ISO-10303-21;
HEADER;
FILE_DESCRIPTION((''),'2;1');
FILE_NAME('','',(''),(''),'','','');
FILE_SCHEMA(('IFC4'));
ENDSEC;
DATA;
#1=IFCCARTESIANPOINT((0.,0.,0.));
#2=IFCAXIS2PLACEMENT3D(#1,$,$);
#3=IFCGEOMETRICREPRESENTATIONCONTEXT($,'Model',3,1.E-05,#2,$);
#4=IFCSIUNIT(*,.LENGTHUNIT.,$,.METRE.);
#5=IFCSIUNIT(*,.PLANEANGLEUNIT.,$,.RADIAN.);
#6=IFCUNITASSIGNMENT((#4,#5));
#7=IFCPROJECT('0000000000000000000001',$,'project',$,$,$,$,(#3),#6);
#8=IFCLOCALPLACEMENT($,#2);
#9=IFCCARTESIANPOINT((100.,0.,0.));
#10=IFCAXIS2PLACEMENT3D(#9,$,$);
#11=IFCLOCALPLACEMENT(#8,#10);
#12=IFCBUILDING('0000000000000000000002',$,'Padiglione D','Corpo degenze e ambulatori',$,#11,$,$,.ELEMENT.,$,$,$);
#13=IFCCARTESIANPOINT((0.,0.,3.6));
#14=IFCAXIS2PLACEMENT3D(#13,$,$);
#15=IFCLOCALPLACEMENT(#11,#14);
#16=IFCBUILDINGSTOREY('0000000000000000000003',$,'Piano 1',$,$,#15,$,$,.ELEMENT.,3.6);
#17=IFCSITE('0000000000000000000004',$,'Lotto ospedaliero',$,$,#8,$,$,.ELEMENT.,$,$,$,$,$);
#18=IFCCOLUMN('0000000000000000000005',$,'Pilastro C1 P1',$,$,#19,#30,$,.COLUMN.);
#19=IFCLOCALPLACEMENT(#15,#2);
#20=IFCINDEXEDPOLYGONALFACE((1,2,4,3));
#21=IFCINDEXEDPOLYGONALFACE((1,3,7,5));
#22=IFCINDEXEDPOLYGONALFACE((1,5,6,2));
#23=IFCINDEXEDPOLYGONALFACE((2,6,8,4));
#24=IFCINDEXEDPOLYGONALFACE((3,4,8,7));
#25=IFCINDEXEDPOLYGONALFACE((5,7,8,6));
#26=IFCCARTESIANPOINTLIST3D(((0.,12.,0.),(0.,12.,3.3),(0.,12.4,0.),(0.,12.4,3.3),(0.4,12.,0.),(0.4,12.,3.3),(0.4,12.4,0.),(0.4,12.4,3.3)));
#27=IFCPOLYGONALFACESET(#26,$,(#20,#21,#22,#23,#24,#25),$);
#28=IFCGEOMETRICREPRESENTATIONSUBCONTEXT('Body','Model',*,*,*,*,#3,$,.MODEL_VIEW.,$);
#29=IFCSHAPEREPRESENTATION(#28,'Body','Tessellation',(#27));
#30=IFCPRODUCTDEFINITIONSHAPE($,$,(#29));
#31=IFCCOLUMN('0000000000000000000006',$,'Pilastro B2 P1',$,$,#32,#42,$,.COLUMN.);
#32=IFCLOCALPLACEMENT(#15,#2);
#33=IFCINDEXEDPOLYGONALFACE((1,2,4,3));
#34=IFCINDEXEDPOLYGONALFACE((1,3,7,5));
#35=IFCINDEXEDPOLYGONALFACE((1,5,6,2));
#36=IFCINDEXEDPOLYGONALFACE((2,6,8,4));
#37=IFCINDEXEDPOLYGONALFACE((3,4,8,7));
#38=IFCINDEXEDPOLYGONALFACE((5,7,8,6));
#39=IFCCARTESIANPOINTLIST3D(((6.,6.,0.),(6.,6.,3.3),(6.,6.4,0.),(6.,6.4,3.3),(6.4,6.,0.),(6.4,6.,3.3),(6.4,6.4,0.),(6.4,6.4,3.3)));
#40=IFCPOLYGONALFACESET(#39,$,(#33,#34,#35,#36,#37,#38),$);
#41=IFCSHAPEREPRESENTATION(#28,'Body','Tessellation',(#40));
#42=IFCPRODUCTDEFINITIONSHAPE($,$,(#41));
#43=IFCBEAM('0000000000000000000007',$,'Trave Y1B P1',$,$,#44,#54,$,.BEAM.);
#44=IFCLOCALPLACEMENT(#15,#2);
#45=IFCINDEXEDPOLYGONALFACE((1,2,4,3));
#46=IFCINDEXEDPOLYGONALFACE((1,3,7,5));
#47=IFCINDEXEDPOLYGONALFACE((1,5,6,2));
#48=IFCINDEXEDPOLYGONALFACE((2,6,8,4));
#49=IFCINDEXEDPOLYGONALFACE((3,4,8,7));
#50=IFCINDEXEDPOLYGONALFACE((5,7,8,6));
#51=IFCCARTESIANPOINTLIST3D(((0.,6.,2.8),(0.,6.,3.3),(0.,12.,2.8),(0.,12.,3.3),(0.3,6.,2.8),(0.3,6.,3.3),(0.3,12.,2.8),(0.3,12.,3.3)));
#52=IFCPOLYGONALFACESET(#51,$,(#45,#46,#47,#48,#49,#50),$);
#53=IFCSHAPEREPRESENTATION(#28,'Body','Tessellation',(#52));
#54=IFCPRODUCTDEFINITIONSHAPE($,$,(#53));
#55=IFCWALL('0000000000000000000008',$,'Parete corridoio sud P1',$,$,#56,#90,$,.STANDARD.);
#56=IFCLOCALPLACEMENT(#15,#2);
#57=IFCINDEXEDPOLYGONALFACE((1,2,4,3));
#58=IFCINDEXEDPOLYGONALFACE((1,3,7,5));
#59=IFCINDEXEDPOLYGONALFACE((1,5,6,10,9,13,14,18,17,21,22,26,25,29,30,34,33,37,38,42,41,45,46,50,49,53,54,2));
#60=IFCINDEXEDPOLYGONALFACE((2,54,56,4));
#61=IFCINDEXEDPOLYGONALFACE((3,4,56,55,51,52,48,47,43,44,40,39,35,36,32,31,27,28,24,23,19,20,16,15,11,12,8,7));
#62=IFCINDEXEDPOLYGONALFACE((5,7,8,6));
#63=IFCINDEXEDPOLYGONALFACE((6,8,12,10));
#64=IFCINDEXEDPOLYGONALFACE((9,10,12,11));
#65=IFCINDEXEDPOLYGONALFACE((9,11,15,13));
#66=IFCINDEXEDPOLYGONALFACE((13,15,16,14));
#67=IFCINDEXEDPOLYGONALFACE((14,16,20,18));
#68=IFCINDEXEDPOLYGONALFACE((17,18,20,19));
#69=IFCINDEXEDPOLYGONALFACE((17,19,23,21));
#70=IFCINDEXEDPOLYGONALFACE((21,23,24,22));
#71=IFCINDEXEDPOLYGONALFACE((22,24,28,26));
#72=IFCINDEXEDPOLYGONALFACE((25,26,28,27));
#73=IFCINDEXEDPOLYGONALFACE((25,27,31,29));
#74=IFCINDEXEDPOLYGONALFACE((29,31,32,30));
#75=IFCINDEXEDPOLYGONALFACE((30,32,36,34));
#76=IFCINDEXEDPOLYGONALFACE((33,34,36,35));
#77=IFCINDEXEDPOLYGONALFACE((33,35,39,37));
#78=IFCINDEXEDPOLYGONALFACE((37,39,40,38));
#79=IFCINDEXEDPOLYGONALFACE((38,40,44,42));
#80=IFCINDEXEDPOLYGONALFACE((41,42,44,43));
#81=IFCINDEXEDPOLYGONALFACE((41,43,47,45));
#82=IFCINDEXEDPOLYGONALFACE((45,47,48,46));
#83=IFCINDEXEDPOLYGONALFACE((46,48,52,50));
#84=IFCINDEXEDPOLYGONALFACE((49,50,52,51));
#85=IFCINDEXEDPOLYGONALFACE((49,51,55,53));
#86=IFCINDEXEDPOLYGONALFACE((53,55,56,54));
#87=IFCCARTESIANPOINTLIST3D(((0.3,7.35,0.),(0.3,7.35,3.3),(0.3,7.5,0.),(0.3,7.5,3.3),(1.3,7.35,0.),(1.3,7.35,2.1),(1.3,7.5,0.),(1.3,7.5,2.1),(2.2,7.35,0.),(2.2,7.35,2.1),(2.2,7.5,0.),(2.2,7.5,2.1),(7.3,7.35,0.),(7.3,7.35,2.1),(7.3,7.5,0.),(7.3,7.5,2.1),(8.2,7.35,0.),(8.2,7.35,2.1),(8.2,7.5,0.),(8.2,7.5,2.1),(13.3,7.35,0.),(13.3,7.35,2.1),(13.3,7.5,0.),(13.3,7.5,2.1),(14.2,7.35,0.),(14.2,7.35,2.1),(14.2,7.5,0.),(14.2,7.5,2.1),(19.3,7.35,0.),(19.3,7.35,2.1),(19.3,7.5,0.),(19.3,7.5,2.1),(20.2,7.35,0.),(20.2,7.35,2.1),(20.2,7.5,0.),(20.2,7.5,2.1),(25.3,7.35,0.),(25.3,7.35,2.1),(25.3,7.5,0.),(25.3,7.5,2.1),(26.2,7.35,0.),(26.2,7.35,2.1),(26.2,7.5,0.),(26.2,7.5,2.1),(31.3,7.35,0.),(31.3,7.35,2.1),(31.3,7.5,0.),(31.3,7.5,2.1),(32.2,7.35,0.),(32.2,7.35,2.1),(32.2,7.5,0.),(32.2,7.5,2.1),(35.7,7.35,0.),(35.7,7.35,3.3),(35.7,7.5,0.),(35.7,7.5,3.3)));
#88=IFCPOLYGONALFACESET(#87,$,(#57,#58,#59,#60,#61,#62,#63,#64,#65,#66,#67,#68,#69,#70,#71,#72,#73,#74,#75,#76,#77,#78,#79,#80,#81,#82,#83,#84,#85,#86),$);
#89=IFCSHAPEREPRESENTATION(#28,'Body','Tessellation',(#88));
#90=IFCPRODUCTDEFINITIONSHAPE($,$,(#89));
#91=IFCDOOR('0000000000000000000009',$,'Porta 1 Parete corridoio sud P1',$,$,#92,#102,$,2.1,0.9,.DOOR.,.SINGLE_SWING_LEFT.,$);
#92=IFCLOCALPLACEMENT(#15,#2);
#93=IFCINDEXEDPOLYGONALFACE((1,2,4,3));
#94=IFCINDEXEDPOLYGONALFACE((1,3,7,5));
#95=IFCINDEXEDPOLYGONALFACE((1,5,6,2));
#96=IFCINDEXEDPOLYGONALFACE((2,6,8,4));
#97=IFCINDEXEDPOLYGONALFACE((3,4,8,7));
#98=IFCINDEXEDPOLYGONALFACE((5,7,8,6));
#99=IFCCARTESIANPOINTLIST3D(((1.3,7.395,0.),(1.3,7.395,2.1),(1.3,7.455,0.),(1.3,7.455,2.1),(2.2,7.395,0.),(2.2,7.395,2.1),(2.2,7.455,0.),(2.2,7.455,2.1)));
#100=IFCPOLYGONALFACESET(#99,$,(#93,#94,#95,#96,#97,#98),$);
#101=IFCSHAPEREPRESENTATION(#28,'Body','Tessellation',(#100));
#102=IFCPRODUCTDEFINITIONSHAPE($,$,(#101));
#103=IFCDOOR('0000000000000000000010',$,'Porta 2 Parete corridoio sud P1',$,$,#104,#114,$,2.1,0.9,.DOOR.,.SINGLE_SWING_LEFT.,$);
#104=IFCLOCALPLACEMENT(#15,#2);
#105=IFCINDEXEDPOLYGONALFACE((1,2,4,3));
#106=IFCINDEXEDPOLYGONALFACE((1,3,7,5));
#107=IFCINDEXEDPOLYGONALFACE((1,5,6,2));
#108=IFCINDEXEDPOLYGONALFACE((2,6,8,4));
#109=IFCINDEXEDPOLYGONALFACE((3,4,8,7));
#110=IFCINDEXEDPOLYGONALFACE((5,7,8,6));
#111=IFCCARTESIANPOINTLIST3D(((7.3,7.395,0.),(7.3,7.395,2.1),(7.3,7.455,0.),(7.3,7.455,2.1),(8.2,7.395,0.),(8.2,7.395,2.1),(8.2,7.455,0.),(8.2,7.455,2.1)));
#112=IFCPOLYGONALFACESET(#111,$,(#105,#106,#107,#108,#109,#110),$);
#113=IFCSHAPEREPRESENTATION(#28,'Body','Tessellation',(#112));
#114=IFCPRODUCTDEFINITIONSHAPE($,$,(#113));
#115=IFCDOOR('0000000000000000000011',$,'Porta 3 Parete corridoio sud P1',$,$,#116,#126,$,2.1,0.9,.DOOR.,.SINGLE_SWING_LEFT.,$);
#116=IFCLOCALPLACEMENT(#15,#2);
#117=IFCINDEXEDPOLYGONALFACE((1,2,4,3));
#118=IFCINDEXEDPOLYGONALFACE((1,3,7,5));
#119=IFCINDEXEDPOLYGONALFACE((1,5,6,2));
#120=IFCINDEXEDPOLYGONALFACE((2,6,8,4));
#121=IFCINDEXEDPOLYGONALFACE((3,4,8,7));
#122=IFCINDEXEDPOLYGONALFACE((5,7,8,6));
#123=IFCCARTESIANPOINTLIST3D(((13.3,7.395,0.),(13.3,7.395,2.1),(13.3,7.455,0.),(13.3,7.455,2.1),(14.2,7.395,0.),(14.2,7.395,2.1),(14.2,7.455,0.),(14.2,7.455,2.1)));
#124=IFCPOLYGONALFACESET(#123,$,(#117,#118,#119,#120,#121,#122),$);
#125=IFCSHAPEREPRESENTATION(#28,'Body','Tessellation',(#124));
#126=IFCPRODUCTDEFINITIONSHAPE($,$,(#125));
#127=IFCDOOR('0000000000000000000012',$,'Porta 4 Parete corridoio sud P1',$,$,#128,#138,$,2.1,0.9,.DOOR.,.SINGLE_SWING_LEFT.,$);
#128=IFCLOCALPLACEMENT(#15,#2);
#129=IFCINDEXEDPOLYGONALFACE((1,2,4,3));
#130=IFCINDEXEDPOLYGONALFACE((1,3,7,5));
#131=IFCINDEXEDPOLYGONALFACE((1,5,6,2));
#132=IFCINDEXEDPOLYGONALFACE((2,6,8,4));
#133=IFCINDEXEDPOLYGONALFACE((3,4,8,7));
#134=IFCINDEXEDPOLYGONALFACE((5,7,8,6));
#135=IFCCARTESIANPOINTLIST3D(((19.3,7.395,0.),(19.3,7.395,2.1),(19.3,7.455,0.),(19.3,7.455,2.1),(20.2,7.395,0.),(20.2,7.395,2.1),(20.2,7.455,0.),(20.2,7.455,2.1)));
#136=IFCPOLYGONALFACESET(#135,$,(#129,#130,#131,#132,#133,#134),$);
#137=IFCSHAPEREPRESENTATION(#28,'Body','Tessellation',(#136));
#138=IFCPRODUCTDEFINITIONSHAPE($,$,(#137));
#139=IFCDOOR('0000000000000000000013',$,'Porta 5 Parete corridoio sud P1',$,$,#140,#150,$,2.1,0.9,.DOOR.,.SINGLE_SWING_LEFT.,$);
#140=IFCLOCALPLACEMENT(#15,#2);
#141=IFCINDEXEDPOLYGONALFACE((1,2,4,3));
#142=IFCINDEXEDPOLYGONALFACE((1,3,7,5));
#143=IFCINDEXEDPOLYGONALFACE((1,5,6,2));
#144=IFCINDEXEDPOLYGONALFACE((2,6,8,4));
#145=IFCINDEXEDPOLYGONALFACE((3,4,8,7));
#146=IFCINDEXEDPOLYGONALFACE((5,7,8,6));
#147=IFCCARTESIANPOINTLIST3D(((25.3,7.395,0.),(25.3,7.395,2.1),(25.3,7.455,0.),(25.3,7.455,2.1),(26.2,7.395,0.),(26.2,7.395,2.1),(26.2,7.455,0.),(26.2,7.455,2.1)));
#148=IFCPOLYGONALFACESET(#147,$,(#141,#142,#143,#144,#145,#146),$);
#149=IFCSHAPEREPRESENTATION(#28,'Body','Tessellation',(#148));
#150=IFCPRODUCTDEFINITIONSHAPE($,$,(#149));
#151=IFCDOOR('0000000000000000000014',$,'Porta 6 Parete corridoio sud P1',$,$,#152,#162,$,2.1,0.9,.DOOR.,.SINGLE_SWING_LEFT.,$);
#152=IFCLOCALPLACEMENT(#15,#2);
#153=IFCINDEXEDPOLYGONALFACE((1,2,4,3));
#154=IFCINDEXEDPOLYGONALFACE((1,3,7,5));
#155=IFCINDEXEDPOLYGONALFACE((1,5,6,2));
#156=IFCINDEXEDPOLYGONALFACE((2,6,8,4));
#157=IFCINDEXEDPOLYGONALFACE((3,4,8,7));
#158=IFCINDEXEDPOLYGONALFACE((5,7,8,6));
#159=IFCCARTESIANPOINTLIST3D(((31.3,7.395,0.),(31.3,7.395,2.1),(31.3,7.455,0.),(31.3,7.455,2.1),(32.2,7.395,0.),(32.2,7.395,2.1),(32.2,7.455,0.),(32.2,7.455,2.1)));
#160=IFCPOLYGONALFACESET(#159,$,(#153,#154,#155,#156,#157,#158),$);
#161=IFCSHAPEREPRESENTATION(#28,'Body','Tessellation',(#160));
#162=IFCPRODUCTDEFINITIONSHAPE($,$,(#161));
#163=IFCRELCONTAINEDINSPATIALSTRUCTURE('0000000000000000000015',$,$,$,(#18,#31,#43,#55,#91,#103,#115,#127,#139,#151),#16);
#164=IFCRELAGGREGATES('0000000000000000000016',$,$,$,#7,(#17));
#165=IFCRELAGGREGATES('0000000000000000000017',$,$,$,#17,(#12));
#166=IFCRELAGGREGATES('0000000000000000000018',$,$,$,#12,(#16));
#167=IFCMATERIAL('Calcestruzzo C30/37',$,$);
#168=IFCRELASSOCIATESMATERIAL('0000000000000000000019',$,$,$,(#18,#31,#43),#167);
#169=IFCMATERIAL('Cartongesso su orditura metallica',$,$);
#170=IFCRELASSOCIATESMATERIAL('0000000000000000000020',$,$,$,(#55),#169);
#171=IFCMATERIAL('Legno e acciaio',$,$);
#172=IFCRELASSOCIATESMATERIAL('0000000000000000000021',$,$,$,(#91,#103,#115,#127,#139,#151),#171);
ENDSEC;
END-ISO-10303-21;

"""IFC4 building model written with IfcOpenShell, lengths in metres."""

from ifc_helpers import new_model, si_unit, frame, frame_2d, origin, place, context, subcontext, project, spatial, rectangle, extrude, material, element, fill, save


model = new_model("IFC4")

# Units and contexts
model_context = context("Model", 3, precision=1e-05, world=origin())
body_context = subcontext(model_context, "Body", "Model", "MODEL_VIEW")
ifc_project = project(units=[si_unit("LENGTHUNIT", "METRE"), si_unit("PLANEANGLEUNIT", "RADIAN")], contexts=[model_context])

# Site, building, storey
site_placement = place(None, origin())
site = spatial("IfcSite", under=ifc_project, at=site_placement, Name="Lotto ospedaliero", CompositionType="ELEMENT")
building_placement = place(site_placement, frame((100.0, 0.0, 0.0)))
building = spatial("IfcBuilding", under=site, at=building_placement, Name="Padiglione D", Description="Corpo degenze e ambulatori", CompositionType="ELEMENT")
storey_placement = place(building_placement, frame((0.0, 0.0, 3.6)))
storey = spatial("IfcBuildingStorey", under=building, at=storey_placement, Name="Piano 1", CompositionType="ELEMENT", Elevation=3.6)

# Columns
ifc_material_1 = material(Name="Calcestruzzo C30/37")
for number, where, name in (
    (1, (0.0, 12.0, 0.0), "Pilastro C1 P1"),
    (2, (6.0, 6.0, 0.0), "Pilastro B2 P1"),
):
    element("IfcColumn", number, at=place(storey_placement, frame(where)), inside=storey, material=ifc_material_1, Name=name, PredefinedType="COLUMN", context=body_context, shape_type="SweptSolid", body=[
        extrude(rectangle(XDim=0.4, YDim=0.4, at=frame_2d((0.2, 0.2))), origin(), (0.0, 0.0, 1.0), 3.3),
    ])

# Beam
beam_placement = place(storey_placement, frame((0.0, 6.0, 2.8)))
element("IfcBeam", 3, at=beam_placement, inside=storey, material=ifc_material_1, Name="Trave Y1B P1", PredefinedType="BEAM", context=body_context, shape_type="SweptSolid", body=[
    extrude(rectangle(XDim=0.3, YDim=6.0, at=frame_2d((0.15, 3.0))), origin(), (0.0, 0.0, 1.0), 0.5),
])

# Wall, openings, doors
ifc_material_2 = material(Name="Cartongesso su orditura metallica")
wall_1_placement = place(storey_placement, frame((0.3, 7.35, 0.0)))
wall_1 = element("IfcWall", 4, at=wall_1_placement, inside=storey, material=ifc_material_2, Name="Parete corridoio sud P1", PredefinedType="STANDARD", context=body_context, shape_type="SweptSolid", body=[
    extrude(rectangle(XDim=35.4, YDim=0.15, at=frame_2d((17.7, 0.075))), origin(), (0.0, 0.0, 1.0), 3.3),
])
opening_1_placement = place(wall_1_placement, frame((1.0, -0.1, 0.0)))
opening_1 = element("IfcOpeningElement", 5, at=opening_1_placement, cuts=wall_1, PredefinedType="OPENING", context=body_context, shape_type="SweptSolid", body=[
    extrude(rectangle(XDim=0.9, YDim=0.35, at=frame_2d((0.45, 0.175))), origin(), (0.0, 0.0, 1.0), 2.1),
])
opening_2_placement = place(wall_1_placement, frame((7.0, -0.1, 0.0)))
opening_2 = element("IfcOpeningElement", 6, at=opening_2_placement, cuts=wall_1, PredefinedType="OPENING", context=body_context, shape_type="SweptSolid", body=[
    extrude(rectangle(XDim=0.9, YDim=0.35, at=frame_2d((0.45, 0.175))), origin(), (0.0, 0.0, 1.0), 2.1),
])
opening_3_placement = place(wall_1_placement, frame((13.0, -0.1, 0.0)))
opening_3 = element("IfcOpeningElement", 7, at=opening_3_placement, cuts=wall_1, PredefinedType="OPENING", context=body_context, shape_type="SweptSolid", body=[
    extrude(rectangle(XDim=0.9, YDim=0.35, at=frame_2d((0.45, 0.175))), origin(), (0.0, 0.0, 1.0), 2.1),
])
opening_4_placement = place(wall_1_placement, frame((19.0, -0.1, 0.0)))
opening_4 = element("IfcOpeningElement", 8, at=opening_4_placement, cuts=wall_1, PredefinedType="OPENING", context=body_context, shape_type="SweptSolid", body=[
    extrude(rectangle(XDim=0.9, YDim=0.35, at=frame_2d((0.45, 0.175))), origin(), (0.0, 0.0, 1.0), 2.1),
])
opening_5_placement = place(wall_1_placement, frame((25.0, -0.1, 0.0)))
opening_5 = element("IfcOpeningElement", 9, at=opening_5_placement, cuts=wall_1, PredefinedType="OPENING", context=body_context, shape_type="SweptSolid", body=[
    extrude(rectangle(XDim=0.9, YDim=0.35, at=frame_2d((0.45, 0.175))), origin(), (0.0, 0.0, 1.0), 2.1),
])
opening_6_placement = place(wall_1_placement, frame((31.0, -0.1, 0.0)))
opening_6 = element("IfcOpeningElement", 10, at=opening_6_placement, cuts=wall_1, PredefinedType="OPENING", context=body_context, shape_type="SweptSolid", body=[
    extrude(rectangle(XDim=0.9, YDim=0.35, at=frame_2d((0.45, 0.175))), origin(), (0.0, 0.0, 1.0), 2.1),
])
ifc_material_3 = material(Name="Legno e acciaio")
door_1_placement = place(wall_1_placement, frame((1.0, 0.045, 0.0)))
door_1 = element("IfcDoor", 11, at=door_1_placement, inside=storey, material=ifc_material_3, Name="Porta 1 Parete corridoio sud P1", OperationType="SINGLE_SWING_LEFT", OverallHeight=2.1, OverallWidth=0.9, PredefinedType="DOOR", context=body_context, shape_type="SweptSolid", body=[
    extrude(rectangle(XDim=0.9, YDim=0.06, at=frame_2d((0.45, 0.03))), origin(), (0.0, 0.0, 1.0), 2.1),
])
fill(opening_1, door_1)
door_2_placement = place(wall_1_placement, frame((7.0, 0.045, 0.0)))
door_2 = element("IfcDoor", 12, at=door_2_placement, inside=storey, material=ifc_material_3, Name="Porta 2 Parete corridoio sud P1", OperationType="SINGLE_SWING_LEFT", OverallHeight=2.1, OverallWidth=0.9, PredefinedType="DOOR", context=body_context, shape_type="SweptSolid", body=[
    extrude(rectangle(XDim=0.9, YDim=0.06, at=frame_2d((0.45, 0.03))), origin(), (0.0, 0.0, 1.0), 2.1),
])
fill(opening_2, door_2)
door_3_placement = place(wall_1_placement, frame((13.0, 0.045, 0.0)))
door_3 = element("IfcDoor", 13, at=door_3_placement, inside=storey, material=ifc_material_3, Name="Porta 3 Parete corridoio sud P1", OperationType="SINGLE_SWING_LEFT", OverallHeight=2.1, OverallWidth=0.9, PredefinedType="DOOR", context=body_context, shape_type="SweptSolid", body=[
    extrude(rectangle(XDim=0.9, YDim=0.06, at=frame_2d((0.45, 0.03))), origin(), (0.0, 0.0, 1.0), 2.1),
])
fill(opening_3, door_3)
door_4_placement = place(wall_1_placement, frame((19.0, 0.045, 0.0)))
door_4 = element("IfcDoor", 14, at=door_4_placement, inside=storey, material=ifc_material_3, Name="Porta 4 Parete corridoio sud P1", OperationType="SINGLE_SWING_LEFT", OverallHeight=2.1, OverallWidth=0.9, PredefinedType="DOOR", context=body_context, shape_type="SweptSolid", body=[
    extrude(rectangle(XDim=0.9, YDim=0.06, at=frame_2d((0.45, 0.03))), origin(), (0.0, 0.0, 1.0), 2.1),
])
fill(opening_4, door_4)
door_5_placement = place(wall_1_placement, frame((25.0, 0.045, 0.0)))
door_5 = element("IfcDoor", 15, at=door_5_placement, inside=storey, material=ifc_material_3, Name="Porta 5 Parete corridoio sud P1", OperationType="SINGLE_SWING_LEFT", OverallHeight=2.1, OverallWidth=0.9, PredefinedType="DOOR", context=body_context, shape_type="SweptSolid", body=[
    extrude(rectangle(XDim=0.9, YDim=0.06, at=frame_2d((0.45, 0.03))), origin(), (0.0, 0.0, 1.0), 2.1),
])
fill(opening_5, door_5)
door_6_placement = place(wall_1_placement, frame((31.0, 0.045, 0.0)))
door_6 = element("IfcDoor", 16, at=door_6_placement, inside=storey, material=ifc_material_3, Name="Porta 6 Parete corridoio sud P1", OperationType="SINGLE_SWING_LEFT", OverallHeight=2.1, OverallWidth=0.9, PredefinedType="DOOR", context=body_context, shape_type="SweptSolid", body=[
    extrude(rectangle(XDim=0.9, YDim=0.06, at=frame_2d((0.45, 0.03))), origin(), (0.0, 0.0, 1.0), 2.1),
])
fill(opening_6, door_6)

save(model, "model.ifc")
